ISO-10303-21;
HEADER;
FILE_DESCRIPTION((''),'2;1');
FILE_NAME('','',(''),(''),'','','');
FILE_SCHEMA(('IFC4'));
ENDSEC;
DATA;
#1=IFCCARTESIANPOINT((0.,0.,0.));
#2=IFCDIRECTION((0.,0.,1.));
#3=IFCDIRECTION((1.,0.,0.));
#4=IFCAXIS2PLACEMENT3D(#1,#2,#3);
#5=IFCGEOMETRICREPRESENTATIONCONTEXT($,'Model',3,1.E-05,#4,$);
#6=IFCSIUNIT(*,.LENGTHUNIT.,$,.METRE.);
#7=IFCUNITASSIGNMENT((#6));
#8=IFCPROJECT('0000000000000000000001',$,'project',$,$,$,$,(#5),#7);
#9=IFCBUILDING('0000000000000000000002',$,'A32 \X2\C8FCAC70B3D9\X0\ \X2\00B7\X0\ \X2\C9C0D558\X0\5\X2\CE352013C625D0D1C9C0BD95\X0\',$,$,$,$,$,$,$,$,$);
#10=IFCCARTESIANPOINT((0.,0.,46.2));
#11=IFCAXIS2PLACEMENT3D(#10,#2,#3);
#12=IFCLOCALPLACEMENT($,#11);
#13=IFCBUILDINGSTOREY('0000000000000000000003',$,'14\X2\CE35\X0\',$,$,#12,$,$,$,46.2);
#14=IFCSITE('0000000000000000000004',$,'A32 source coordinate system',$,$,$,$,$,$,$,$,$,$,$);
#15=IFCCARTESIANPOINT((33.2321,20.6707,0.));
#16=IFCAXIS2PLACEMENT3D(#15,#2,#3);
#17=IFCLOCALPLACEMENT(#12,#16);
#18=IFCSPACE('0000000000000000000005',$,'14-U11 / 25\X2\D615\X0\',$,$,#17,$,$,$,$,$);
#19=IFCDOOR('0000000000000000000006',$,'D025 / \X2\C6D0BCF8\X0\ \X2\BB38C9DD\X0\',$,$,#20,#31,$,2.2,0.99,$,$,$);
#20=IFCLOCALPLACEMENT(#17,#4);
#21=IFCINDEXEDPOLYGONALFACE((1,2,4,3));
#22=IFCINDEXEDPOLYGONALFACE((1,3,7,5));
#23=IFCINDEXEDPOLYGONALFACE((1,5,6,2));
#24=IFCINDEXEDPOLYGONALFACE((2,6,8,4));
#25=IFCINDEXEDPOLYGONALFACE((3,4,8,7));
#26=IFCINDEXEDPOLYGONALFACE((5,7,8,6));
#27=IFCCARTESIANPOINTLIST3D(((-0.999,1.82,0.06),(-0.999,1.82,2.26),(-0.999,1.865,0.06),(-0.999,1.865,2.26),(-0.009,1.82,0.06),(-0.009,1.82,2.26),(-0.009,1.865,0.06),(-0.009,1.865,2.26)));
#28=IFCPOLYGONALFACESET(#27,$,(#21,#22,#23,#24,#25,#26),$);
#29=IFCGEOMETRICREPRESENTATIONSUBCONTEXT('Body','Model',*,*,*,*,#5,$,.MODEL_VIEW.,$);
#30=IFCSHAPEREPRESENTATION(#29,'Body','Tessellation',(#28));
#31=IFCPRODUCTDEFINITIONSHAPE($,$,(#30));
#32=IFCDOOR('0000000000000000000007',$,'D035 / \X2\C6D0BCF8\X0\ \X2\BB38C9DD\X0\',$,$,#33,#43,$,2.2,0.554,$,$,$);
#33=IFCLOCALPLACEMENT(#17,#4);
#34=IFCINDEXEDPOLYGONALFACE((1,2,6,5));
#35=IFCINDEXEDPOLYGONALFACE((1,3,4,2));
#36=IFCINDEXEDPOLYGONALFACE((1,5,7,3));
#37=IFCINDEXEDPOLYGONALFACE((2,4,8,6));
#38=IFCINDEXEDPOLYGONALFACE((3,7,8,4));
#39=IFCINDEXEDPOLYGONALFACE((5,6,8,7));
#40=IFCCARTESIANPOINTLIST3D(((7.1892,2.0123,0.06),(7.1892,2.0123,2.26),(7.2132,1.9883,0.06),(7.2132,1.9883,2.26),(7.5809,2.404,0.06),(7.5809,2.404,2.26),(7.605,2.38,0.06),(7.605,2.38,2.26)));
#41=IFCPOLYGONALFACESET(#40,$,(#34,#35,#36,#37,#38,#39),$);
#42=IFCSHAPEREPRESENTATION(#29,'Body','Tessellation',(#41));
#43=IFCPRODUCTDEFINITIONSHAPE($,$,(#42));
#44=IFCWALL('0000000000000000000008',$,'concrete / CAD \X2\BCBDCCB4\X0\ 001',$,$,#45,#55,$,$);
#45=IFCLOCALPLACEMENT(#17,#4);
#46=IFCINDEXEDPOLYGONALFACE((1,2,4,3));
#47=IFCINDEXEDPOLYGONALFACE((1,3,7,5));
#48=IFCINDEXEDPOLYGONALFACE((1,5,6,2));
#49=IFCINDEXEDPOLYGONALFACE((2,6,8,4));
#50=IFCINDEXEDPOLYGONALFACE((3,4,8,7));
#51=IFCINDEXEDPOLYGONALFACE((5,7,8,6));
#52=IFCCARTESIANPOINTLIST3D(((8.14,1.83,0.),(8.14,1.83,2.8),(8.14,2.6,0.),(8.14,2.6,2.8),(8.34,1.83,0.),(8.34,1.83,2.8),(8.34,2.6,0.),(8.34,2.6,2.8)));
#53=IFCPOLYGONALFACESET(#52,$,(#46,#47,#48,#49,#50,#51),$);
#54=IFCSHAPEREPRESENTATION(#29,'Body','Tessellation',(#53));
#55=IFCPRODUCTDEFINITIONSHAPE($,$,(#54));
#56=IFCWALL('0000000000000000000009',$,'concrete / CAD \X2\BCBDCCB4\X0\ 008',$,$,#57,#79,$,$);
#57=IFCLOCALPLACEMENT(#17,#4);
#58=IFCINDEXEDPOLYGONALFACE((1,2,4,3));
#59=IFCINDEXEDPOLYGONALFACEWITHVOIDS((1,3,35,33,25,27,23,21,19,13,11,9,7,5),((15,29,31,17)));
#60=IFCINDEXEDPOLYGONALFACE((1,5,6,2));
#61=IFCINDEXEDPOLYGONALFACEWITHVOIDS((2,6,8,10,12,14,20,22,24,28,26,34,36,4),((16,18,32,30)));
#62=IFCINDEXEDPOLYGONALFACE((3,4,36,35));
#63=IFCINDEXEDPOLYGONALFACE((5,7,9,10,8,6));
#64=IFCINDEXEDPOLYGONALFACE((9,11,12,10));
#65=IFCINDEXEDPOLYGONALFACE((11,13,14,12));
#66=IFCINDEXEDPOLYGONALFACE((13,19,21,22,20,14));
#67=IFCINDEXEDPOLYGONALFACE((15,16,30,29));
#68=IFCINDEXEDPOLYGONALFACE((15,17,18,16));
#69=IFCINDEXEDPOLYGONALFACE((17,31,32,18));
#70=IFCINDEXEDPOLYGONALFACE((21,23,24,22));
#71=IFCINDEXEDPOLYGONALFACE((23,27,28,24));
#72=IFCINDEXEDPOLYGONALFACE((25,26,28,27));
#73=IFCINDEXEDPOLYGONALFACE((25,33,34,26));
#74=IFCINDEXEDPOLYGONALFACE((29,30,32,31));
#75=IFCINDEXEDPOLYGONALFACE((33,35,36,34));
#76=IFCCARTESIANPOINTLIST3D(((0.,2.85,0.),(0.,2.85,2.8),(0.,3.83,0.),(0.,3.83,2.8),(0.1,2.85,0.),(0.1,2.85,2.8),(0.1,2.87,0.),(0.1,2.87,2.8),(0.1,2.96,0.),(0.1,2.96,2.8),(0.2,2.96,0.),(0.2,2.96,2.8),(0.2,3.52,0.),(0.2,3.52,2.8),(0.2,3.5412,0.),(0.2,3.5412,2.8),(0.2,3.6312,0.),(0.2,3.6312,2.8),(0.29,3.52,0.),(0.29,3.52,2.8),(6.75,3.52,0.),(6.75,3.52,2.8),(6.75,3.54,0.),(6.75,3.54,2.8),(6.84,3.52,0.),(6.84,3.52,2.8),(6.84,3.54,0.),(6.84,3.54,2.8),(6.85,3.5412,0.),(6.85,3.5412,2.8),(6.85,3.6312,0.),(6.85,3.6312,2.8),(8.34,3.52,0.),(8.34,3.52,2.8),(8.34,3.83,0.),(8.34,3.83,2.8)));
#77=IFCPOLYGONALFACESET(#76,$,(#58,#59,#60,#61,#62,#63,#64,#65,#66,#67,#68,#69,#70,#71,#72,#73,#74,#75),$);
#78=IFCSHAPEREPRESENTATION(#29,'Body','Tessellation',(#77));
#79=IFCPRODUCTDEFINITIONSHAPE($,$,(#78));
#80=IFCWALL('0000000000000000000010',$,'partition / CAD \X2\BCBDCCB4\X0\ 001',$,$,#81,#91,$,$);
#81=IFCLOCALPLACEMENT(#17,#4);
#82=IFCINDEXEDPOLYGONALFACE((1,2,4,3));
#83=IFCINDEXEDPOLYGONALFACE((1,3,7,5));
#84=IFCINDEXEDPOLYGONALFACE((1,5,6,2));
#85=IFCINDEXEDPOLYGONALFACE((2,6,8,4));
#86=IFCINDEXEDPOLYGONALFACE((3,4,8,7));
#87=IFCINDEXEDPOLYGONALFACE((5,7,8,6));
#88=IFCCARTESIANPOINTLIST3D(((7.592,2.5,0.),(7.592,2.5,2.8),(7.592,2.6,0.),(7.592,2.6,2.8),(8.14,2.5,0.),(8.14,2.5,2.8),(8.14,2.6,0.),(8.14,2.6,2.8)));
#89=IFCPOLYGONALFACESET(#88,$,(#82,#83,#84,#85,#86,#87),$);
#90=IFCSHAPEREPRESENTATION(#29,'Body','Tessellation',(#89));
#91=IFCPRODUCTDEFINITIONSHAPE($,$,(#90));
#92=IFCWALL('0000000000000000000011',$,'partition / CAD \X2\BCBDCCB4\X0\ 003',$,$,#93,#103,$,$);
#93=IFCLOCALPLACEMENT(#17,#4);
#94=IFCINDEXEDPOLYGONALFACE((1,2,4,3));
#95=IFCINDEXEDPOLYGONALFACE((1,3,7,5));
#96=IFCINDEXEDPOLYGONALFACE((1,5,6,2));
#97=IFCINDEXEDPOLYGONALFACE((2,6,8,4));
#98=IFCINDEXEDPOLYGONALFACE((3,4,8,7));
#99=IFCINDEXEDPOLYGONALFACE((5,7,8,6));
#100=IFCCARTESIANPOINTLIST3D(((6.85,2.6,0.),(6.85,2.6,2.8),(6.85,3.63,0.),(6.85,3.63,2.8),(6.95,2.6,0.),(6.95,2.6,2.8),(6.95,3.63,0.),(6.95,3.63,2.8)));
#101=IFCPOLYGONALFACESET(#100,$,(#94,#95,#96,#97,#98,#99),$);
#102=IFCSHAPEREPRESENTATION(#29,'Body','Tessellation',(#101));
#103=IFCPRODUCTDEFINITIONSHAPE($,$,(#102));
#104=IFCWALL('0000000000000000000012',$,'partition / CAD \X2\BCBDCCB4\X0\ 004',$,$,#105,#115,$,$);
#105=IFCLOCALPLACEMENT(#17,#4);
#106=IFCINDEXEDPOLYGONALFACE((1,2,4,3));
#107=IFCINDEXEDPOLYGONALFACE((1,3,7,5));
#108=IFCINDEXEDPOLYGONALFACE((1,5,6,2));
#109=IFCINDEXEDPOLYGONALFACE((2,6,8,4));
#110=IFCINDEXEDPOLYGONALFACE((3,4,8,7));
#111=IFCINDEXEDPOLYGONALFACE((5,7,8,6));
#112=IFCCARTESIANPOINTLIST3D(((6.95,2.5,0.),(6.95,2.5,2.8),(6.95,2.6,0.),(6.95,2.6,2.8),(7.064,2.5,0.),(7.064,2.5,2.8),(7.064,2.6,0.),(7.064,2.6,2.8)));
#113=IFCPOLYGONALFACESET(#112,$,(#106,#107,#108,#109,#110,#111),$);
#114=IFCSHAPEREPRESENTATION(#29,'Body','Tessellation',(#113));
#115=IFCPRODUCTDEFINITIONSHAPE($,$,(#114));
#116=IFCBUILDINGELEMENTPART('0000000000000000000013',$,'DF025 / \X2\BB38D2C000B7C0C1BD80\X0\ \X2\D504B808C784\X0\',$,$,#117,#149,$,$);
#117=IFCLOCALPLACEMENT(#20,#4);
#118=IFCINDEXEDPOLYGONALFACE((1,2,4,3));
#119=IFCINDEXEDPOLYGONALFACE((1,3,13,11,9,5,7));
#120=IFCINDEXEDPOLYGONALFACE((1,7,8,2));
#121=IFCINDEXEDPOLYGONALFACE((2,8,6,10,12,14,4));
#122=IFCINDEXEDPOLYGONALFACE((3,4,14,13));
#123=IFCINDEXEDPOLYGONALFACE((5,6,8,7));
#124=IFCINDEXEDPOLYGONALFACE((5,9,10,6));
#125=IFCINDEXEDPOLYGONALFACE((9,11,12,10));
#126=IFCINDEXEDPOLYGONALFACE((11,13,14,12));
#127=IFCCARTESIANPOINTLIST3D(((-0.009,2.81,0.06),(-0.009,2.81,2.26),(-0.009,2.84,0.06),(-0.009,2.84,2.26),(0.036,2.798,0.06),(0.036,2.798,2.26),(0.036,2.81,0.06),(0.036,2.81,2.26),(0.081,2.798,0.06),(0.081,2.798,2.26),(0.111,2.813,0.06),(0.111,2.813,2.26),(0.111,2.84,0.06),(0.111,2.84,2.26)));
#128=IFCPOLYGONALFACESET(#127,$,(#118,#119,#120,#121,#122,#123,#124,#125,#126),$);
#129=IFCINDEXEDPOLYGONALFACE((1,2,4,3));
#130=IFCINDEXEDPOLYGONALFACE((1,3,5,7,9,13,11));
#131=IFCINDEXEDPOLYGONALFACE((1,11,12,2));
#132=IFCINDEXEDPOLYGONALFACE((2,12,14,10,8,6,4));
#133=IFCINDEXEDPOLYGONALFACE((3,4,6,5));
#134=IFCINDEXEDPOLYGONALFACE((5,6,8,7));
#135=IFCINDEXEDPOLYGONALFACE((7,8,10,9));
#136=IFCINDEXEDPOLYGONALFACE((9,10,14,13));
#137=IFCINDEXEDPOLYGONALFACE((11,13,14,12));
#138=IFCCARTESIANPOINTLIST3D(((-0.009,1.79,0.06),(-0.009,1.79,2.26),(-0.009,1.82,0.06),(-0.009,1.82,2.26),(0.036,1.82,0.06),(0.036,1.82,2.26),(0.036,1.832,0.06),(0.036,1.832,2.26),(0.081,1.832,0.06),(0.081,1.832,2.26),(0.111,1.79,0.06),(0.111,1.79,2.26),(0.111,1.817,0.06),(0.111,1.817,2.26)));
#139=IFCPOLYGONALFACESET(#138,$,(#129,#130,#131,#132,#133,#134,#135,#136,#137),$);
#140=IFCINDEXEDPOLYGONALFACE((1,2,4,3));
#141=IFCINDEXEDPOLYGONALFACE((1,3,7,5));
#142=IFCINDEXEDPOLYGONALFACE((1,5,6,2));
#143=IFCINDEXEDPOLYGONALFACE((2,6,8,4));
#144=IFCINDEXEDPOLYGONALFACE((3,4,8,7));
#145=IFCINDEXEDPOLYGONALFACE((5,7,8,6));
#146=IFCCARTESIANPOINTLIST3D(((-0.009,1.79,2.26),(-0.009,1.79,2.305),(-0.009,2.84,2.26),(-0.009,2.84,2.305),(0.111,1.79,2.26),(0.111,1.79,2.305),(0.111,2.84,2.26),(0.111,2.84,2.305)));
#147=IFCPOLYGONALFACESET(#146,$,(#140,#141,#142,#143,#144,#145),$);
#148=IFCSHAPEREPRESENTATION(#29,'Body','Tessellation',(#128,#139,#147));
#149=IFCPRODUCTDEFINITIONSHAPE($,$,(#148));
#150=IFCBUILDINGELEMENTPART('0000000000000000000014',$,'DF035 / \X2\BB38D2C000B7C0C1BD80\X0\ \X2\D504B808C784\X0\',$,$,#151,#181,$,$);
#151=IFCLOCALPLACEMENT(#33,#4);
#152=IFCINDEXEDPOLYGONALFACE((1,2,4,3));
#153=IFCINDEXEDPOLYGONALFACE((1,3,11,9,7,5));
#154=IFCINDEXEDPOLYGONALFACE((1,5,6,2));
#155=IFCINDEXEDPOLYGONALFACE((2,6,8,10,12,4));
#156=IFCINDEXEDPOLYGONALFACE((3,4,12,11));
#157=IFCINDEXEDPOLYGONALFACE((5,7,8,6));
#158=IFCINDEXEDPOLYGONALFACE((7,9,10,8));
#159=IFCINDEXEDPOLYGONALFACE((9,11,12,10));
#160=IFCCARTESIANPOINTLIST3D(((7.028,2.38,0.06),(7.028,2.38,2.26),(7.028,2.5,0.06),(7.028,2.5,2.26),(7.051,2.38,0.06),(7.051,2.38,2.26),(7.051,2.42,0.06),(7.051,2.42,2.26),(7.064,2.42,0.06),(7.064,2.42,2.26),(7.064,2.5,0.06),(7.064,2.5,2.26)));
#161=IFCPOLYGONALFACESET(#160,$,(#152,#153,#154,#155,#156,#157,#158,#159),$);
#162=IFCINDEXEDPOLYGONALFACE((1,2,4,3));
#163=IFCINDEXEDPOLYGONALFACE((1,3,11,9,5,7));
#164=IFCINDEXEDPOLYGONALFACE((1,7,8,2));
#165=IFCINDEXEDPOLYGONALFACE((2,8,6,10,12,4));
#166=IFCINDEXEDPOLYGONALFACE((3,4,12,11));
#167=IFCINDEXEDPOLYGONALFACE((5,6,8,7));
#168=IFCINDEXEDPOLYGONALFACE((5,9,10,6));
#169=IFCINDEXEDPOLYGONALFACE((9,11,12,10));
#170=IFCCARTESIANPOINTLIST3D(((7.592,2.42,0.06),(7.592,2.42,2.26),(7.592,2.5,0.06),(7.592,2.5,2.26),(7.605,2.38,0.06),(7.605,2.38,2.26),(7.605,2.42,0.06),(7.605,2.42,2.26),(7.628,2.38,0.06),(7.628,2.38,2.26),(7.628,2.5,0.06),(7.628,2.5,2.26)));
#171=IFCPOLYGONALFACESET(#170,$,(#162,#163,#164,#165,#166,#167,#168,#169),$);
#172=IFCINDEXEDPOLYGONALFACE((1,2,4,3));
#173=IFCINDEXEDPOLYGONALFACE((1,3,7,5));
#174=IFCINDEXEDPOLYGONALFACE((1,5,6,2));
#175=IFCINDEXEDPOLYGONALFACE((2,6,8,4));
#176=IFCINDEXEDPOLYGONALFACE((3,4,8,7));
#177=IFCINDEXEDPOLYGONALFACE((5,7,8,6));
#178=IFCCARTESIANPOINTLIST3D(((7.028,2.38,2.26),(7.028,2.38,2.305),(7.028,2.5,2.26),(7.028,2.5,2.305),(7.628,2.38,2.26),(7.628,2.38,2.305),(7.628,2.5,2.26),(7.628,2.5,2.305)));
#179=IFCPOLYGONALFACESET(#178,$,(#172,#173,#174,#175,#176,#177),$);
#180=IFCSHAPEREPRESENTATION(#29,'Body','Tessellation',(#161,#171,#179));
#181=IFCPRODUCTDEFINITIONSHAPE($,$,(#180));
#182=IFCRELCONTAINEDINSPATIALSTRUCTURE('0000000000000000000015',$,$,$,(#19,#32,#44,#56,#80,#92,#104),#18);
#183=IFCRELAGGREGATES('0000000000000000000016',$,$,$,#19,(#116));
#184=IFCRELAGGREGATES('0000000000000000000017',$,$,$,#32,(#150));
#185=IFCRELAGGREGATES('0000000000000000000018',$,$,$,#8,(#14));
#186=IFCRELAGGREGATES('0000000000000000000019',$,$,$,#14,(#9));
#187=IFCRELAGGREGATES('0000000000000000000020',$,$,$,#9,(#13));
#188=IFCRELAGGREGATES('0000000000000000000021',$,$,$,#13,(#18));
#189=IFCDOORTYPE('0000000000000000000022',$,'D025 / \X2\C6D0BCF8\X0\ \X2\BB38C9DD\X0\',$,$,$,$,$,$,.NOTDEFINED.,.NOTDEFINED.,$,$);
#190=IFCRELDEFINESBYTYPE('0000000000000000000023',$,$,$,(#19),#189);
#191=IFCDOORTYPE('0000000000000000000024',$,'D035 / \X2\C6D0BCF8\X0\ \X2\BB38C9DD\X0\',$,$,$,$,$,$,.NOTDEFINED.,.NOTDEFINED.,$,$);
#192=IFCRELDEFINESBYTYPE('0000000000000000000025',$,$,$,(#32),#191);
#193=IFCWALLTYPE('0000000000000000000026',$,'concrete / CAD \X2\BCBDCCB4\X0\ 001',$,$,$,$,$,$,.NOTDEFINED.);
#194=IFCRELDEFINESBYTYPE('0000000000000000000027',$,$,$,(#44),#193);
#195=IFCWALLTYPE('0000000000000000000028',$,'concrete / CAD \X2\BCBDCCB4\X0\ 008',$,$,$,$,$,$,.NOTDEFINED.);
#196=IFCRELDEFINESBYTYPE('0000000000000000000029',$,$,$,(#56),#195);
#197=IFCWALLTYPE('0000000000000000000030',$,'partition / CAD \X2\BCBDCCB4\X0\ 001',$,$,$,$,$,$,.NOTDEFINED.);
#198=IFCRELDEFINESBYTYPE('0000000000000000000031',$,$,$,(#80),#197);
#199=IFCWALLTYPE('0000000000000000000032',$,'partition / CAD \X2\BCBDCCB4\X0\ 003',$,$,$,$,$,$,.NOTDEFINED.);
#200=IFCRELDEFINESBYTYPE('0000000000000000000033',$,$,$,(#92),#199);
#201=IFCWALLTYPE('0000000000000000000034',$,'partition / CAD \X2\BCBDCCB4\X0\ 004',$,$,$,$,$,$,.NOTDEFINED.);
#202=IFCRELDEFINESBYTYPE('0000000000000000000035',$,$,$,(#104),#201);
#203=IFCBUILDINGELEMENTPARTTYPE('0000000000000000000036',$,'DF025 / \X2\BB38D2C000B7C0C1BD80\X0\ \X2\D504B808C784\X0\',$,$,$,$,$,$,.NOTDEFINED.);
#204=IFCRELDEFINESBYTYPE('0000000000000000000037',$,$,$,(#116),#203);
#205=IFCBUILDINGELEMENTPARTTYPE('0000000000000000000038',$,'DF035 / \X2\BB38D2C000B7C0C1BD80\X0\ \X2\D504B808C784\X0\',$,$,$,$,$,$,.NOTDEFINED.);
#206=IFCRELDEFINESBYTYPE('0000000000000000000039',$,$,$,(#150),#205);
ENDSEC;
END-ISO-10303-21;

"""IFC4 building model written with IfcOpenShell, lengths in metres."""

from ifc_helpers import new_model, si_unit, frame, origin, origin_with_axes, place, context, subcontext, project, spatial, polyline, outline, extrude, source, transform, mapped, type_object, type_shapes, element, aggregate, save


model = new_model("IFC4")

# Units and contexts
model_context = context("Model", 3, precision=1e-05, world=origin_with_axes())
body_context = subcontext(model_context, "Body", "Model", "MODEL_VIEW")
ifc_project = project(units=[si_unit("LENGTHUNIT", "METRE")], contexts=[model_context])

# Site, building, storey, space
storey_placement = place(None, frame((0.0, 0.0, 46.2), z_axis=(0.0, 0.0, 1.0), x_axis=(1.0, 0.0, 0.0)))
space_placement = place(storey_placement, frame((33.2321, 20.6707, 0.0), z_axis=(0.0, 0.0, 1.0), x_axis=(1.0, 0.0, 0.0)))
site = spatial("IfcSite", under=ifc_project, Name="A32 source coordinate system")
building = spatial("IfcBuilding", under=site, Name="A32 주거동 · 지하5층–옥탑지붕")
storey = spatial("IfcBuildingStorey", under=building, at=storey_placement, Name="14층", Elevation=46.2)
space = spatial("IfcSpace", under=storey, at=space_placement, Name="14-U11 / 25형")

# Doors
door_type_1 = type_object("IfcDoorType", Name="D025 / 원본 문짝", OperationType="NOTDEFINED", PredefinedType="NOTDEFINED")
shared_shape_1 = source(origin(), body_context, "Body", "SweptSolid", [
    extrude(outline(polyline([(-0.009, 1.82), (-0.999, 1.82), (-0.999, 1.865), (-0.009, 1.865), (-0.009, 1.82)])), frame((0.0, 0.0, 0.06)), (0.0, 0.0, 1.0), 2.2),
])
type_shapes(door_type_1, [shared_shape_1])
door_1_placement = place(space_placement, origin_with_axes())
door_1 = element("IfcDoor", 1, at=door_1_placement, inside=space, type_object=door_type_1, Name="D025 / 원본 문짝", OverallHeight=2.2, OverallWidth=0.99, context=body_context, shape_type="MappedRepresentation", body=[
    mapped(shared_shape_1, transform((0.0, 0.0, 0.0), scale=1.0)),
])
door_type_2 = type_object("IfcDoorType", Name="D035 / 원본 문짝", OperationType="NOTDEFINED", PredefinedType="NOTDEFINED")
shared_shape_2 = source(origin(), body_context, "Body", "SweptSolid", [
    extrude(outline(polyline([(7.605, 2.38), (7.2132, 1.9883), (7.1892, 2.0123), (7.5809, 2.404), (7.605, 2.38)])), frame((0.0, 0.0, 0.06)), (0.0, 0.0, 1.0), 2.2),
])
type_shapes(door_type_2, [shared_shape_2])
door_2_placement = place(space_placement, origin_with_axes())
door_2 = element("IfcDoor", 2, at=door_2_placement, inside=space, type_object=door_type_2, Name="D035 / 원본 문짝", OverallHeight=2.2, OverallWidth=0.554, context=body_context, shape_type="MappedRepresentation", body=[
    mapped(shared_shape_2, transform((0.0, 0.0, 0.0), scale=1.0)),
])

# Walls
wall_type_1 = type_object("IfcWallType", Name="concrete / CAD 벽체 001", PredefinedType="NOTDEFINED")
shared_shape_3 = source(origin(), body_context, "Body", "SweptSolid", [
    extrude(outline(polyline([(8.34, 1.83), (8.14, 1.83), (8.14, 2.6), (8.34, 2.6), (8.34, 1.83)])), origin(), (0.0, 0.0, 1.0), 2.8),
])
type_shapes(wall_type_1, [shared_shape_3])
wall_1_placement = place(space_placement, origin_with_axes())
element("IfcWall", 3, at=wall_1_placement, inside=space, type_object=wall_type_1, Name="concrete / CAD 벽체 001", context=body_context, shape_type="MappedRepresentation", body=[
    mapped(shared_shape_3, transform((0.0, 0.0, 0.0), scale=1.0)),
])
wall_type_2 = type_object("IfcWallType", Name="concrete / CAD 벽체 008", PredefinedType="NOTDEFINED")
shared_shape_4 = source(origin(), body_context, "Body", "SweptSolid", [
    extrude(outline(polyline([(0.0, 3.83), (8.34, 3.83), (8.34, 3.52), (6.84, 3.52), (6.84, 3.54), (6.75, 3.54), (6.75, 3.52), (0.29, 3.52), (0.2, 3.52), (0.2, 2.96), (0.1, 2.96), (0.1, 2.87), (0.1, 2.85), (0.0, 2.85), (0.0, 3.83)]), holes=[polyline([(6.85, 3.5412), (6.85, 3.6312), (0.2, 3.6312), (0.2, 3.5412), (6.85, 3.5412)])]), origin(), (0.0, 0.0, 1.0), 2.8),
])
type_shapes(wall_type_2, [shared_shape_4])
wall_2_placement = place(space_placement, origin_with_axes())
element("IfcWall", 4, at=wall_2_placement, inside=space, type_object=wall_type_2, Name="concrete / CAD 벽체 008", context=body_context, shape_type="MappedRepresentation", body=[
    mapped(shared_shape_4, transform((0.0, 0.0, 0.0), scale=1.0)),
])
wall_type_3 = type_object("IfcWallType", Name="partition / CAD 벽체 001", PredefinedType="NOTDEFINED")
shared_shape_5 = source(origin(), body_context, "Body", "SweptSolid", [
    extrude(outline(polyline([(8.14, 2.6), (8.14, 2.5), (7.592, 2.5), (7.592, 2.6), (8.14, 2.6)])), origin(), (0.0, 0.0, 1.0), 2.8),
])
type_shapes(wall_type_3, [shared_shape_5])
wall_3_placement = place(space_placement, origin_with_axes())
element("IfcWall", 5, at=wall_3_placement, inside=space, type_object=wall_type_3, Name="partition / CAD 벽체 001", context=body_context, shape_type="MappedRepresentation", body=[
    mapped(shared_shape_5, transform((0.0, 0.0, 0.0), scale=1.0)),
])
wall_type_4 = type_object("IfcWallType", Name="partition / CAD 벽체 003", PredefinedType="NOTDEFINED")
shared_shape_6 = source(origin(), body_context, "Body", "SweptSolid", [
    extrude(outline(polyline([(6.85, 2.6), (6.85, 3.63), (6.95, 3.63), (6.95, 2.6), (6.85, 2.6)])), origin(), (0.0, 0.0, 1.0), 2.8),
])
type_shapes(wall_type_4, [shared_shape_6])
wall_4_placement = place(space_placement, origin_with_axes())
element("IfcWall", 6, at=wall_4_placement, inside=space, type_object=wall_type_4, Name="partition / CAD 벽체 003", context=body_context, shape_type="MappedRepresentation", body=[
    mapped(shared_shape_6, transform((0.0, 0.0, 0.0), scale=1.0)),
])
wall_type_5 = type_object("IfcWallType", Name="partition / CAD 벽체 004", PredefinedType="NOTDEFINED")
shared_shape_7 = source(origin(), body_context, "Body", "SweptSolid", [
    extrude(outline(polyline([(6.95, 2.5), (6.95, 2.6), (7.064, 2.6), (7.064, 2.5), (6.95, 2.5)])), origin(), (0.0, 0.0, 1.0), 2.8),
])
type_shapes(wall_type_5, [shared_shape_7])
wall_5_placement = place(space_placement, origin_with_axes())
element("IfcWall", 7, at=wall_5_placement, inside=space, type_object=wall_type_5, Name="partition / CAD 벽체 004", context=body_context, shape_type="MappedRepresentation", body=[
    mapped(shared_shape_7, transform((0.0, 0.0, 0.0), scale=1.0)),
])

# Building element parts
building_element_part_type_1 = type_object("IfcBuildingElementPartType", Name="DF025 / 문틀·상부 프레임", PredefinedType="NOTDEFINED")
shared_shape_8 = source(origin(), body_context, "Body", "SweptSolid", [
    extrude(outline(polyline([(0.111, 2.84), (0.111, 2.813), (0.081, 2.798), (0.036, 2.798), (0.036, 2.81), (-0.009, 2.81), (-0.009, 2.84), (0.111, 2.84)])), frame((0.0, 0.0, 0.06)), (0.0, 0.0, 1.0), 2.2),
    extrude(outline(polyline([(-0.009, 1.82), (0.036, 1.82), (0.036, 1.832), (0.081, 1.832), (0.111, 1.817), (0.111, 1.79), (-0.009, 1.79), (-0.009, 1.82)])), frame((0.0, 0.0, 0.06)), (0.0, 0.0, 1.0), 2.2),
    extrude(outline(polyline([(-0.009, 1.79), (-0.009, 2.84), (0.111, 2.84), (0.111, 1.79), (-0.009, 1.79)])), frame((0.0, 0.0, 2.26)), (0.0, 0.0, 1.0), 0.045),
])
type_shapes(building_element_part_type_1, [shared_shape_8])
building_element_part_1_placement = place(door_1_placement, origin_with_axes())
building_element_part_1 = element("IfcBuildingElementPart", 8, at=building_element_part_1_placement, type_object=building_element_part_type_1, Name="DF025 / 문틀·상부 프레임", context=body_context, shape_type="MappedRepresentation", body=[
    mapped(shared_shape_8, transform((0.0, 0.0, 0.0), scale=1.0)),
])
aggregate(door_1, [building_element_part_1])
building_element_part_type_2 = type_object("IfcBuildingElementPartType", Name="DF035 / 문틀·상부 프레임", PredefinedType="NOTDEFINED")
shared_shape_9 = source(origin(), body_context, "Body", "SweptSolid", [
    extrude(outline(polyline([(7.064, 2.5), (7.064, 2.42), (7.051, 2.42), (7.051, 2.38), (7.028, 2.38), (7.028, 2.5), (7.064, 2.5)])), frame((0.0, 0.0, 0.06)), (0.0, 0.0, 1.0), 2.2),
    extrude(outline(polyline([(7.628, 2.38), (7.605, 2.38), (7.605, 2.42), (7.592, 2.42), (7.592, 2.5), (7.628, 2.5), (7.628, 2.38)])), frame((0.0, 0.0, 0.06)), (0.0, 0.0, 1.0), 2.2),
    extrude(outline(polyline([(7.028, 2.38), (7.028, 2.5), (7.628, 2.5), (7.628, 2.38), (7.028, 2.38)])), frame((0.0, 0.0, 2.26)), (0.0, 0.0, 1.0), 0.045),
])
type_shapes(building_element_part_type_2, [shared_shape_9])
building_element_part_2_placement = place(door_2_placement, origin_with_axes())
building_element_part_2 = element("IfcBuildingElementPart", 9, at=building_element_part_2_placement, type_object=building_element_part_type_2, Name="DF035 / 문틀·상부 프레임", context=body_context, shape_type="MappedRepresentation", body=[
    mapped(shared_shape_9, transform((0.0, 0.0, 0.0), scale=1.0)),
])
aggregate(door_2, [building_element_part_2])

save(model, "model.ifc")
